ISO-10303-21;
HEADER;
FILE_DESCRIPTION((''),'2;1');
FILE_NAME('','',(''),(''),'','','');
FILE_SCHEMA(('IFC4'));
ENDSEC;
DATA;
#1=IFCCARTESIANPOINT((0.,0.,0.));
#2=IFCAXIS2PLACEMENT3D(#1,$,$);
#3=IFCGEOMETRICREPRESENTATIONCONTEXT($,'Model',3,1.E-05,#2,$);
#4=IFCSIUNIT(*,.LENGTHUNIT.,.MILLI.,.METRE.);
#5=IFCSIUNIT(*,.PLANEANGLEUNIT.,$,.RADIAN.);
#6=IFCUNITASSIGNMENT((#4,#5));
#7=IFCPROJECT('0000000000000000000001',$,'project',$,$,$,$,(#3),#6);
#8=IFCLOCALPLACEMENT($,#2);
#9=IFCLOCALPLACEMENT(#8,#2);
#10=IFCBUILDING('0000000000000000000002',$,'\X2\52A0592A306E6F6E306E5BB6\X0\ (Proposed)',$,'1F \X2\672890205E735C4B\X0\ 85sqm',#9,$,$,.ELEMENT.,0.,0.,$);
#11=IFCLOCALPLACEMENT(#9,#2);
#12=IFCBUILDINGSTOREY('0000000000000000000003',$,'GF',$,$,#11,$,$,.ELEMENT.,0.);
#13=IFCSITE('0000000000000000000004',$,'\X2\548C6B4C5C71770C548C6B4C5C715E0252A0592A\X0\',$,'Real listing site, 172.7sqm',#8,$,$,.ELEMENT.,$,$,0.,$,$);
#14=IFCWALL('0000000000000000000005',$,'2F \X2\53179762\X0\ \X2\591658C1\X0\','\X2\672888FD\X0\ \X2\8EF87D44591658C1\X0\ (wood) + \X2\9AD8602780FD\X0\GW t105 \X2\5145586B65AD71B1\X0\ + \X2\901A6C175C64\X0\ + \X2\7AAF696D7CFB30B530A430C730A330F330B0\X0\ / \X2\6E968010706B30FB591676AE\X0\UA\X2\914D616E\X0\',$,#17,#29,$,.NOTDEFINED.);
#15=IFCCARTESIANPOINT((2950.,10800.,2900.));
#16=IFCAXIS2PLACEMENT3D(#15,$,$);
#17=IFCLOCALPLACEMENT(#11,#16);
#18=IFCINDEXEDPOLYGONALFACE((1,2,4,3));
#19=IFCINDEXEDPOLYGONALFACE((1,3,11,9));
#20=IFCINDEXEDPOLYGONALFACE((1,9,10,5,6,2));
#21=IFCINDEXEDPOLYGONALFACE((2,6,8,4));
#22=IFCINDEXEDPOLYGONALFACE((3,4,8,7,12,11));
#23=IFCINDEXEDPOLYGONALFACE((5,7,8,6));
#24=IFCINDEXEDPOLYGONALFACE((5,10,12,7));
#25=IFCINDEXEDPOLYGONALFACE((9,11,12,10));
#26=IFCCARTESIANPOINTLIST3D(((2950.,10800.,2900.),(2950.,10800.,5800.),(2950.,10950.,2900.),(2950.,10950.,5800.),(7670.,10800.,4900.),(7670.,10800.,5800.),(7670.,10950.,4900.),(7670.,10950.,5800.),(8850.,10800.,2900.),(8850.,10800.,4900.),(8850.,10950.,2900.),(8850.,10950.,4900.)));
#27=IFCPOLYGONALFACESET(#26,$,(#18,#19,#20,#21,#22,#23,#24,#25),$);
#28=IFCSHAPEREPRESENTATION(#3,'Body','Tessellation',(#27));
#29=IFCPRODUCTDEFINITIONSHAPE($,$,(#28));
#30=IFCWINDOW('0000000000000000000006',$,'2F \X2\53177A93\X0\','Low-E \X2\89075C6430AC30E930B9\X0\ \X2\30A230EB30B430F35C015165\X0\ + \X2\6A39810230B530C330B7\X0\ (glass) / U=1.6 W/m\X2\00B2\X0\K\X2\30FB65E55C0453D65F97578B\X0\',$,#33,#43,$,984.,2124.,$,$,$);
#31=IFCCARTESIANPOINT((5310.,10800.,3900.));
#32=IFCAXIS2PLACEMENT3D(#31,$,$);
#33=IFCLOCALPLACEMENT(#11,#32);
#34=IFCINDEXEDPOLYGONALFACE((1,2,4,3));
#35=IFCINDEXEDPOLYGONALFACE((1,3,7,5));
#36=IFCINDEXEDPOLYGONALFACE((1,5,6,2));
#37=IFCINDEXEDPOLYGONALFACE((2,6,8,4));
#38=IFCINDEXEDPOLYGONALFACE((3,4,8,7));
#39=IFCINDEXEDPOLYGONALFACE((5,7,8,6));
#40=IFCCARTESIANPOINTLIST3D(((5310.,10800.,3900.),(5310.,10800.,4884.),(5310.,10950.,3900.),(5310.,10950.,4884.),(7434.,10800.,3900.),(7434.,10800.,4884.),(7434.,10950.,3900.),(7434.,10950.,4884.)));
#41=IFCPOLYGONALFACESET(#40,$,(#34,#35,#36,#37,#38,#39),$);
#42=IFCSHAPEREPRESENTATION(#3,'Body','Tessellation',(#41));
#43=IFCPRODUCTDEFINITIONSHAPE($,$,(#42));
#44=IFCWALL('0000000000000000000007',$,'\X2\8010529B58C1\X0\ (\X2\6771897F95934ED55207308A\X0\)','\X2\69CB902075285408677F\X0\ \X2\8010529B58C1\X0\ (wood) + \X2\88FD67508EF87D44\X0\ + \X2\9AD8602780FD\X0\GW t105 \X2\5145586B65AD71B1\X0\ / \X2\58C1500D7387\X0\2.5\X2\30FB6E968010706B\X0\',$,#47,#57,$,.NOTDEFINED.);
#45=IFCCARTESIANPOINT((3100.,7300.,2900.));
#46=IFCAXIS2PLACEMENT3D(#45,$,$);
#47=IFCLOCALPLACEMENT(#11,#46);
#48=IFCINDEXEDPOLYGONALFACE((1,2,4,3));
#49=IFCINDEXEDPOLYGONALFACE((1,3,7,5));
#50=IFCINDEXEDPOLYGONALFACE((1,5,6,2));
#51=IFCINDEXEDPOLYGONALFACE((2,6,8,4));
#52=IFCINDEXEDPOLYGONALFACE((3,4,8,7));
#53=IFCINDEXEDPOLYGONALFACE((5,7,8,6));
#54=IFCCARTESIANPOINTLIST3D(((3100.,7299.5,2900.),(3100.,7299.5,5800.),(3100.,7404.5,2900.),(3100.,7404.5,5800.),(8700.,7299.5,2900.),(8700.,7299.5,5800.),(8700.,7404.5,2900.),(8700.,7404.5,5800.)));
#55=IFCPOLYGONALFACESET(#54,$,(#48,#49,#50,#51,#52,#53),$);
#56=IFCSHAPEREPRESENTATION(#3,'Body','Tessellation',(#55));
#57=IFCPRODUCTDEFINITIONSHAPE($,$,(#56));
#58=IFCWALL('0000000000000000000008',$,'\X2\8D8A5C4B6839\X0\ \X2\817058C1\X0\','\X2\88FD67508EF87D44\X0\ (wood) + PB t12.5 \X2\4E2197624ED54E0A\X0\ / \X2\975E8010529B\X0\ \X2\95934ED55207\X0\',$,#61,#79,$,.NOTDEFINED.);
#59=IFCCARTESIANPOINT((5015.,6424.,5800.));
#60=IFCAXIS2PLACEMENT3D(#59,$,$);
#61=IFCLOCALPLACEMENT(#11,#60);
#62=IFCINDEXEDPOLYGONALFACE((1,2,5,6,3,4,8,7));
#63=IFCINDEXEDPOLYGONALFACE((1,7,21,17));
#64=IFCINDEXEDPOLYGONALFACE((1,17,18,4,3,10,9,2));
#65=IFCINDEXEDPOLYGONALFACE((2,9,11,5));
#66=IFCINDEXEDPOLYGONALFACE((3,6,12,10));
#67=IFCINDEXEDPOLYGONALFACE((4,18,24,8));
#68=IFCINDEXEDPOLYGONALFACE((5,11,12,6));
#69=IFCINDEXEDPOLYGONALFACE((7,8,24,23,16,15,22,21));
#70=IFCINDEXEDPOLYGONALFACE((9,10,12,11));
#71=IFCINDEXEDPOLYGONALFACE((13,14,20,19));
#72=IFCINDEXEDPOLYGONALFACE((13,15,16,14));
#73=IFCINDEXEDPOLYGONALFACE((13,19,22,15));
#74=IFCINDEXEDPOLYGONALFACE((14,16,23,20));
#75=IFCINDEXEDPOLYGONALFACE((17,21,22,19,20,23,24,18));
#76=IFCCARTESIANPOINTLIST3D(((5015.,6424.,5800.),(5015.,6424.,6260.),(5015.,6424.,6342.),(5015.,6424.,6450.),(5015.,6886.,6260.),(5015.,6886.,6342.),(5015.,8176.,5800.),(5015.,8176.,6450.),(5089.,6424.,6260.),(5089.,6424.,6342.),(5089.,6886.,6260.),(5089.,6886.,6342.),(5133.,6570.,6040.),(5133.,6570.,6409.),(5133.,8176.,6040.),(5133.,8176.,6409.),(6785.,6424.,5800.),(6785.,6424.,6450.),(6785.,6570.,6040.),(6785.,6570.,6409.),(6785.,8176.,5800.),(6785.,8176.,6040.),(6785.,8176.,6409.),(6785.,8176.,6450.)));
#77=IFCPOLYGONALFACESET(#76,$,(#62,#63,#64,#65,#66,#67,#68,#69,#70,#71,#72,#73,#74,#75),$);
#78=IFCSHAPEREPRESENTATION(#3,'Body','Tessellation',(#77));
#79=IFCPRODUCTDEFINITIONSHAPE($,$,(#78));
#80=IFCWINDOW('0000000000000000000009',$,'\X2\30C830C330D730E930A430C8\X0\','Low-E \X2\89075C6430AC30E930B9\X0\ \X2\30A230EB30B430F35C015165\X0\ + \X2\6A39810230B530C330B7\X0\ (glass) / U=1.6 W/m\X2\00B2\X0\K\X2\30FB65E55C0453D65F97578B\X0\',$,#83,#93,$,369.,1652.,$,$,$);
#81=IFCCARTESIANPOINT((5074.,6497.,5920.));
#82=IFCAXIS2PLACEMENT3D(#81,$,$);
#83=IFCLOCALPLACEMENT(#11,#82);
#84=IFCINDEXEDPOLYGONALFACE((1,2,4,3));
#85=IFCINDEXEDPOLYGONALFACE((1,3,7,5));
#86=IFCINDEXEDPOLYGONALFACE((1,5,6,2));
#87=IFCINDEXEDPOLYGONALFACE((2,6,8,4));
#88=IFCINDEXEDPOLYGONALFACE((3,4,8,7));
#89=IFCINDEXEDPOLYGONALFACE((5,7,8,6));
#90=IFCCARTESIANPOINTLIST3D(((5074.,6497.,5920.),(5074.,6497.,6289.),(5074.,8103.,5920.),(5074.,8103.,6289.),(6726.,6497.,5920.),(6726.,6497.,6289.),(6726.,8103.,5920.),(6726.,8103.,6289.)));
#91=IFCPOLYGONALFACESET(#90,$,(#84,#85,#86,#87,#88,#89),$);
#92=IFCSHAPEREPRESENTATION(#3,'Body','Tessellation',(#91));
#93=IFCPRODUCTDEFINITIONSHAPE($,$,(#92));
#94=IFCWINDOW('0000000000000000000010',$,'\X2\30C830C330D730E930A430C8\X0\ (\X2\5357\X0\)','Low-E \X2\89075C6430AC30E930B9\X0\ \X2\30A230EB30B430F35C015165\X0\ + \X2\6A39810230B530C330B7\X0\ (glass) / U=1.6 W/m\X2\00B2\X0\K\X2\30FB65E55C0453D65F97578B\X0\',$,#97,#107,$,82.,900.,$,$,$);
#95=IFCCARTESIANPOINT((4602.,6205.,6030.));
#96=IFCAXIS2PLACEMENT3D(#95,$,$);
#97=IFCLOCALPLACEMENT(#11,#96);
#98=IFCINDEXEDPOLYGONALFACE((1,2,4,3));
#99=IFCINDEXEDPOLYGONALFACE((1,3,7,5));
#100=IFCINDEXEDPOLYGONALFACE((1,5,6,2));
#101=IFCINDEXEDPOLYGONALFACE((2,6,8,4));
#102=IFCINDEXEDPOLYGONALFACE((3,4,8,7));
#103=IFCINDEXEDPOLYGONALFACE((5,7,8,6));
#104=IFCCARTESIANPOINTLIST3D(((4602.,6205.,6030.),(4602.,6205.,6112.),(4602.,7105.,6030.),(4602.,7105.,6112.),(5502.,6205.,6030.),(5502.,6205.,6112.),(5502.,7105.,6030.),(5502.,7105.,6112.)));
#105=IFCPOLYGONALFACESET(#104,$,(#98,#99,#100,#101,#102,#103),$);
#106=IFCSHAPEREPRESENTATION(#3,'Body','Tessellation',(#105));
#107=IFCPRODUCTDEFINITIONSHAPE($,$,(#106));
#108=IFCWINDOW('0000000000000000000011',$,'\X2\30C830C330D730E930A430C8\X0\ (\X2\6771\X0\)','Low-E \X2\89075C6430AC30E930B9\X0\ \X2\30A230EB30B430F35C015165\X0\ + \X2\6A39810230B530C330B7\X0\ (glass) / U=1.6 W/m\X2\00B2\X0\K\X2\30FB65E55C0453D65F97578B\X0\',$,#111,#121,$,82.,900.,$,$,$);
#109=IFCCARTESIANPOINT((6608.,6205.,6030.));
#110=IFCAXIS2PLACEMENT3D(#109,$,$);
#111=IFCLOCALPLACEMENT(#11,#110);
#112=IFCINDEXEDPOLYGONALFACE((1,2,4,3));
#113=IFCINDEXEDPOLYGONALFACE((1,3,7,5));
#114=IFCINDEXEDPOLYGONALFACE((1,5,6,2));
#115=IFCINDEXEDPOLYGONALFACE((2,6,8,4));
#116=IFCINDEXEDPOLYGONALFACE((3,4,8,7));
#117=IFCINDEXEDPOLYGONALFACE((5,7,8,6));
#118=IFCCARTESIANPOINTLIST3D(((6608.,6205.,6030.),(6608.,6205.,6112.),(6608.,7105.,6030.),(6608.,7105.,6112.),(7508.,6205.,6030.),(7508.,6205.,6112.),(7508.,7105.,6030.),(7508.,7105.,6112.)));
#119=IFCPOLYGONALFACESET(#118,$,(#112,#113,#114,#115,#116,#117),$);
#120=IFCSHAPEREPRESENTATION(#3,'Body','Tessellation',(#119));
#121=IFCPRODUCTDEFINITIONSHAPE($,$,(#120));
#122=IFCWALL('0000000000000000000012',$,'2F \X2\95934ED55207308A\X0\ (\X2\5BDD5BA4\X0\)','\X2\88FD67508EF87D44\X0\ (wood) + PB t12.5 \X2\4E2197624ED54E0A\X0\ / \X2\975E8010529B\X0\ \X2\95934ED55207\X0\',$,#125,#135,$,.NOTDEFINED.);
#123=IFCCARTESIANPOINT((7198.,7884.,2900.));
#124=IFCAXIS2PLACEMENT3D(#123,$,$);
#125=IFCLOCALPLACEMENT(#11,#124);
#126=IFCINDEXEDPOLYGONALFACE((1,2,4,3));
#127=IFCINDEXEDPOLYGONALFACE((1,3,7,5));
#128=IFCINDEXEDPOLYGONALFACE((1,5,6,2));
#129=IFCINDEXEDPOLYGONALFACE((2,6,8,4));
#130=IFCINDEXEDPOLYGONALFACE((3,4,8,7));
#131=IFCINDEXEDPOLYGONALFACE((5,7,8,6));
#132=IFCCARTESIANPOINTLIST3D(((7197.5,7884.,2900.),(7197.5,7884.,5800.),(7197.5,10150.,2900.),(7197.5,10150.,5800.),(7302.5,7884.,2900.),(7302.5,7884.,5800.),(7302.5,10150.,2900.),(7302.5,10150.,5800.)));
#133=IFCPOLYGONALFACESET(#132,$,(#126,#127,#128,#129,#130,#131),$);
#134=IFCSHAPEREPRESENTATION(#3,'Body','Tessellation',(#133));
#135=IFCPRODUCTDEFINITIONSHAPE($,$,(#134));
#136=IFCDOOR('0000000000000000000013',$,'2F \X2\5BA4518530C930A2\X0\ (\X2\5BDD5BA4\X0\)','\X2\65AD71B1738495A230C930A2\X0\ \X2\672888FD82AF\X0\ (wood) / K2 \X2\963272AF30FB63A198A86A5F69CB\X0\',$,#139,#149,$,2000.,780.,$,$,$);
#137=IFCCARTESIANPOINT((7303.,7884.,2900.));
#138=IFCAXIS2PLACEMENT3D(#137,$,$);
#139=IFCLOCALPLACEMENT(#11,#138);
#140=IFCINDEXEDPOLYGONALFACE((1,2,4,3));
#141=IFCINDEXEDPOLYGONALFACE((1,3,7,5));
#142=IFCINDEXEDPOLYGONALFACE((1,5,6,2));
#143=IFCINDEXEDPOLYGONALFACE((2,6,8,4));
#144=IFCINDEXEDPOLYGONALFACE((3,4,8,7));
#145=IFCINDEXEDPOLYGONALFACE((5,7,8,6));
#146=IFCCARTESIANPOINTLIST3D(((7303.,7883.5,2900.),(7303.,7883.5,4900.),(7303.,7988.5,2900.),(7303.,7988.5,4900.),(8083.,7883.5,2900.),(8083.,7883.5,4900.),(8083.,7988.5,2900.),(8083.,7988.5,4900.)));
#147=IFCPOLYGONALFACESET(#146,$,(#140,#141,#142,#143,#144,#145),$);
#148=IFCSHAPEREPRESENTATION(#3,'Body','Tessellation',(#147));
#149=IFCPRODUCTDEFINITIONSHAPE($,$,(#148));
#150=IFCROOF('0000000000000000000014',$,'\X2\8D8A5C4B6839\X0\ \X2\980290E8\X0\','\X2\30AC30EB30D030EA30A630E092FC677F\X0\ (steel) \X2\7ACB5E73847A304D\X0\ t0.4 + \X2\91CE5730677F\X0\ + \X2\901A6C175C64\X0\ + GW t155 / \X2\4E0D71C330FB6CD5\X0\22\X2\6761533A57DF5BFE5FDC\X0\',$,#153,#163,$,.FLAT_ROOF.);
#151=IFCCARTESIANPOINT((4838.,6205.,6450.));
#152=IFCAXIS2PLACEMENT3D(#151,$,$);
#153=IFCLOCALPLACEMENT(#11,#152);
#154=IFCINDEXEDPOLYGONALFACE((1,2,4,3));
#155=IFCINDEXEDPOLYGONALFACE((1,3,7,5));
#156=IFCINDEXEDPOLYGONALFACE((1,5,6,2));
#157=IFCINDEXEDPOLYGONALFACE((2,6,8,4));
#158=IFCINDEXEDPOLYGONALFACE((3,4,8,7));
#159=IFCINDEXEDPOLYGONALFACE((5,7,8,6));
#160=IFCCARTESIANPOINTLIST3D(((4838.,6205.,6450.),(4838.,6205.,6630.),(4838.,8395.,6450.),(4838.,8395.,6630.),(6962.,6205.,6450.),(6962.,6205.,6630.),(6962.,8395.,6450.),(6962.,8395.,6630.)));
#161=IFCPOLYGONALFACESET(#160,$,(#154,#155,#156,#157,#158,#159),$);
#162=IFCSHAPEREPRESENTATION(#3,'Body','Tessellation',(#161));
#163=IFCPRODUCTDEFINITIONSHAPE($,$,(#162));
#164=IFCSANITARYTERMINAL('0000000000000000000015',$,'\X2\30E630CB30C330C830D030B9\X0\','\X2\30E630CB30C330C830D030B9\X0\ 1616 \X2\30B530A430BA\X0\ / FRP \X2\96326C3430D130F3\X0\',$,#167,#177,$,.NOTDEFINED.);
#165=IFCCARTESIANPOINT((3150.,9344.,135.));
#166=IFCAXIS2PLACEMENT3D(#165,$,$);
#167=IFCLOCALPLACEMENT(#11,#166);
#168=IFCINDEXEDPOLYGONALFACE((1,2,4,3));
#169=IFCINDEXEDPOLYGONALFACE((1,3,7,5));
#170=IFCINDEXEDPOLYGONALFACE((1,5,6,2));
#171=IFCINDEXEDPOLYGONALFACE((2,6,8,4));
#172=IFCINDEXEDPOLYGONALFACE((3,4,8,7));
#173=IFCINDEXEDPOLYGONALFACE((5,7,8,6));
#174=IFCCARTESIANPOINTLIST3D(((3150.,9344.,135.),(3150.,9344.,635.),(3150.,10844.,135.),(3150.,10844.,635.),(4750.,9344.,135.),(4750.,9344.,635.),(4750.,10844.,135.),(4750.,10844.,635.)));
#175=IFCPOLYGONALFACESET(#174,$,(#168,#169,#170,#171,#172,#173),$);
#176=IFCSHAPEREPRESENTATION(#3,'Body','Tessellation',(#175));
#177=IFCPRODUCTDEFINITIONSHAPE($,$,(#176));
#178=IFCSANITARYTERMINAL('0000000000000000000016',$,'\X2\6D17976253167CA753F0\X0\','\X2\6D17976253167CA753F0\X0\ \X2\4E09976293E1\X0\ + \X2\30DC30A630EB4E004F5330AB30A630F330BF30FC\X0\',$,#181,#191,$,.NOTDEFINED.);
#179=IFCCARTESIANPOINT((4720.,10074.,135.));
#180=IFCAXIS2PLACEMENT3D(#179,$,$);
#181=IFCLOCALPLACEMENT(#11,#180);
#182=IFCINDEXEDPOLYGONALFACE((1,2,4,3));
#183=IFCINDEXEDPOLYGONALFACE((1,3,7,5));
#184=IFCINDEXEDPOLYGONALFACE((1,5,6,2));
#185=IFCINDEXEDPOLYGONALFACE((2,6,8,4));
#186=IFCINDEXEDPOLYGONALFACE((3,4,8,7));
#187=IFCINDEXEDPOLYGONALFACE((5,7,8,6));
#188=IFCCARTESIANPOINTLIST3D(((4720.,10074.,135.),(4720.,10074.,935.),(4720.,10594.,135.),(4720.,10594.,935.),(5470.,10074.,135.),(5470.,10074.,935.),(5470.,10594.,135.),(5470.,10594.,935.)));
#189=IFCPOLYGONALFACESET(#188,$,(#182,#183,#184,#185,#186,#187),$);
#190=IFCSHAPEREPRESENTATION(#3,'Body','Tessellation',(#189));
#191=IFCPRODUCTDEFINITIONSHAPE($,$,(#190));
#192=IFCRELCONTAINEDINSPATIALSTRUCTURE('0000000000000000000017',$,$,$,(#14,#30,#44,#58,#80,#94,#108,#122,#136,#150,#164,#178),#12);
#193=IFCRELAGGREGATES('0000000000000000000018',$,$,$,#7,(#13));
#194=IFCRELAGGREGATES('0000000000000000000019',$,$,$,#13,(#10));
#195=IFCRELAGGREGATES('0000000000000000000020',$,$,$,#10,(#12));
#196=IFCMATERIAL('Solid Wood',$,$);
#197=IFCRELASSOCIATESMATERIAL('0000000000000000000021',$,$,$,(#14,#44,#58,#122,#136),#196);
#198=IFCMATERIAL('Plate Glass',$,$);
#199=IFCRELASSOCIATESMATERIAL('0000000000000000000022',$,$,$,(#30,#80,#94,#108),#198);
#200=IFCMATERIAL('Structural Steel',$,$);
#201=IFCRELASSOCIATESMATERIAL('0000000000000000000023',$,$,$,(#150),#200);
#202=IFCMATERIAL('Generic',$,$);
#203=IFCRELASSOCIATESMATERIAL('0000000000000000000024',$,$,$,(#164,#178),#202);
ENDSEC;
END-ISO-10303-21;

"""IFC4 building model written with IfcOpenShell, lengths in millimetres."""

from ifc_helpers import new_model, si_unit, frame, frame_2d, origin, place, context, project, spatial, rectangle, extrude, material, element, fill, save


model = new_model("IFC4")

# Units and contexts
model_context = context("Model", 3, precision=1e-05, world=origin())
ifc_project = project(units=[si_unit("LENGTHUNIT", "METRE", prefix="MILLI"), si_unit("PLANEANGLEUNIT", "RADIAN")], contexts=[model_context])

# Site, building, storey
site_placement = place(None, origin())
site = spatial("IfcSite", under=ifc_project, at=site_placement, Name="和歌山県和歌山市加太", ObjectType="Real listing site, 172.7sqm", CompositionType="ELEMENT", RefElevation=0.0)
building_placement = place(site_placement, origin())
building = spatial("IfcBuilding", under=site, at=building_placement, Name="加太の潮の家 (Proposed)", ObjectType="1F 木造平屋 85sqm", CompositionType="ELEMENT", ElevationOfRefHeight=0.0, ElevationOfTerrain=0.0)
storey_placement = place(building_placement, origin())
storey = spatial("IfcBuildingStorey", under=building, at=storey_placement, Name="GF", CompositionType="ELEMENT", Elevation=0.0)

# Wall, opening, window
ifc_material_1 = material(Name="Solid Wood")
wall_1_placement = place(storey_placement, frame((2950.0, 10800.0, 2900.0)))
wall_1 = element("IfcWall", 1, at=wall_1_placement, inside=storey, material=ifc_material_1, Name="2F 北面 外壁", Description="木製 軸組外壁 (wood) + 高性能GW t105 充填断熱 + 通気層 + 窯業系サイディング / 準耐火・外皮UA配慮", PredefinedType="NOTDEFINED", context=model_context, shape_type="SweptSolid", body=[
    extrude(rectangle(XDim=5900.0, YDim=150.0, at=frame_2d((2950.0, 75.0))), frame((2950.0, 10800.0, 2900.0)), (0.0, 0.0, 1.0), 2900.0),
])
opening_1_placement = place(storey_placement, frame((5310.0, 10800.0, 3900.0)))
opening_1 = element("IfcOpeningElement", 2, at=opening_1_placement, cuts=wall_1, PredefinedType="NOTDEFINED", context=model_context, shape_type="SweptSolid", body=[
    extrude(rectangle(XDim=2124.0, YDim=150.0, at=frame_2d((1062.0, 75.0))), frame((5310.0, 10800.0, 3900.0)), (0.0, 0.0, 1.0), 984.0),
])
ifc_material_2 = material(Name="Plate Glass")
window_1_placement = place(storey_placement, frame((5310.0, 10800.0, 3900.0)))
window_1 = element("IfcWindow", 3, at=window_1_placement, inside=storey, material=ifc_material_2, Name="2F 北窓", Description="Low-E 複層ガラス アルゴン封入 + 樹脂サッシ (glass) / U=1.6 W/m²K・日射取得型", OverallHeight=984.0, OverallWidth=2124.0, context=model_context, shape_type="SweptSolid", body=[
    extrude(rectangle(XDim=2124.0, YDim=150.0, at=frame_2d((1062.0, 75.0))), frame((5310.0, 10800.0, 3900.0)), (0.0, 0.0, 1.0), 984.0),
])
fill(opening_1, window_1)

# Wall
wall_2_placement = place(storey_placement, frame((3100.0, 7300.0, 2900.0)))
element("IfcWall", 4, at=wall_2_placement, inside=storey, material=ifc_material_1, Name="耐力壁 (東西間仕切り)", Description="構造用合板 耐力壁 (wood) + 製材軸組 + 高性能GW t105 充填断熱 / 壁倍率2.5・準耐火", PredefinedType="NOTDEFINED", context=model_context, shape_type="SweptSolid", body=[
    extrude(rectangle(XDim=5600.0, YDim=105.0, at=frame_2d((2800.0, 52.0))), frame((3100.0, 7300.0, 2900.0)), (0.0, 0.0, 1.0), 2900.0),
])

# Wall, openings, windows
wall_3_placement = place(storey_placement, frame((5015.0, 6424.0, 5800.0)))
wall_3 = element("IfcWall", 5, at=wall_3_placement, inside=storey, material=ifc_material_1, Name="越屋根 腰壁", Description="製材軸組 (wood) + PB t12.5 両面仕上 / 非耐力 間仕切", PredefinedType="NOTDEFINED", context=model_context, shape_type="SweptSolid", body=[
    extrude(rectangle(XDim=1770.0, YDim=1752.0, at=frame_2d((885.0, 876.0))), frame((5015.0, 6424.0, 5800.0)), (0.0, 0.0, 1.0), 650.0),
])
opening_2_placement = place(storey_placement, frame((5074.0, 6497.0, 5920.0)))
opening_2 = element("IfcOpeningElement", 6, at=opening_2_placement, cuts=wall_3, PredefinedType="NOTDEFINED", context=model_context, shape_type="SweptSolid", body=[
    extrude(rectangle(XDim=1652.0, YDim=1606.0, at=frame_2d((826.0, 803.0))), frame((5074.0, 6497.0, 5920.0)), (0.0, 0.0, 1.0), 369.0),
])
opening_3_placement = place(storey_placement, frame((4602.0, 6205.0, 6030.0)))
opening_3 = element("IfcOpeningElement", 7, at=opening_3_placement, cuts=wall_3, PredefinedType="NOTDEFINED", context=model_context, shape_type="SweptSolid", body=[
    extrude(rectangle(XDim=900.0, YDim=900.0, at=frame_2d((450.0, 450.0))), frame((4602.0, 6205.0, 6030.0)), (0.0, 0.0, 1.0), 82.0),
])
opening_4_placement = place(storey_placement, frame((6608.0, 6205.0, 6030.0)))
opening_4 = element("IfcOpeningElement", 8, at=opening_4_placement, cuts=wall_3, PredefinedType="NOTDEFINED", context=model_context, shape_type="SweptSolid", body=[
    extrude(rectangle(XDim=900.0, YDim=900.0, at=frame_2d((450.0, 450.0))), frame((6608.0, 6205.0, 6030.0)), (0.0, 0.0, 1.0), 82.0),
])
window_2_placement = place(storey_placement, frame((5074.0, 6497.0, 5920.0)))
window_2 = element("IfcWindow", 9, at=window_2_placement, inside=storey, material=ifc_material_2, Name="トップライト", Description="Low-E 複層ガラス アルゴン封入 + 樹脂サッシ (glass) / U=1.6 W/m²K・日射取得型", OverallHeight=369.0, OverallWidth=1652.0, context=model_context, shape_type="SweptSolid", body=[
    extrude(rectangle(XDim=1652.0, YDim=1606.0, at=frame_2d((826.0, 803.0))), frame((5074.0, 6497.0, 5920.0)), (0.0, 0.0, 1.0), 369.0),
])
fill(opening_2, window_2)
window_3_placement = place(storey_placement, frame((4602.0, 6205.0, 6030.0)))
window_3 = element("IfcWindow", 10, at=window_3_placement, inside=storey, material=ifc_material_2, Name="トップライト (南)", Description="Low-E 複層ガラス アルゴン封入 + 樹脂サッシ (glass) / U=1.6 W/m²K・日射取得型", OverallHeight=82.0, OverallWidth=900.0, context=model_context, shape_type="SweptSolid", body=[
    extrude(rectangle(XDim=900.0, YDim=900.0, at=frame_2d((450.0, 450.0))), frame((4602.0, 6205.0, 6030.0)), (0.0, 0.0, 1.0), 82.0),
])
fill(opening_3, window_3)
window_4_placement = place(storey_placement, frame((6608.0, 6205.0, 6030.0)))
window_4 = element("IfcWindow", 11, at=window_4_placement, inside=storey, material=ifc_material_2, Name="トップライト (東)", Description="Low-E 複層ガラス アルゴン封入 + 樹脂サッシ (glass) / U=1.6 W/m²K・日射取得型", OverallHeight=82.0, OverallWidth=900.0, context=model_context, shape_type="SweptSolid", body=[
    extrude(rectangle(XDim=900.0, YDim=900.0, at=frame_2d((450.0, 450.0))), frame((6608.0, 6205.0, 6030.0)), (0.0, 0.0, 1.0), 82.0),
])
fill(opening_4, window_4)

# Wall
wall_4_placement = place(storey_placement, frame((7198.0, 7884.0, 2900.0)))
element("IfcWall", 12, at=wall_4_placement, inside=storey, material=ifc_material_1, Name="2F 間仕切り (寝室)", Description="製材軸組 (wood) + PB t12.5 両面仕上 / 非耐力 間仕切", PredefinedType="NOTDEFINED", context=model_context, shape_type="SweptSolid", body=[
    extrude(rectangle(XDim=105.0, YDim=2266.0, at=frame_2d((52.0, 1133.0))), frame((7198.0, 7884.0, 2900.0)), (0.0, 0.0, 1.0), 2900.0),
])

# Door
door_placement = place(storey_placement, frame((7303.0, 7884.0, 2900.0)))
element("IfcDoor", 13, at=door_placement, inside=storey, material=ifc_material_1, Name="2F 室内ドア (寝室)", Description="断熱玄関ドア 木製芯 (wood) / K2 防犯・採風機構", OverallHeight=2000.0, OverallWidth=780.0, context=model_context, shape_type="SweptSolid", body=[
    extrude(rectangle(XDim=780.0, YDim=105.0, at=frame_2d((390.0, 52.0))), frame((7303.0, 7884.0, 2900.0)), (0.0, 0.0, 1.0), 2000.0),
])

# Roof
ifc_material_3 = material(Name="Structural Steel")
roof_placement = place(storey_placement, frame((4838.0, 6205.0, 6450.0)))
element("IfcRoof", 14, at=roof_placement, inside=storey, material=ifc_material_3, Name="越屋根 頂部", Description="ガルバリウム鋼板 (steel) 立平葺き t0.4 + 野地板 + 通気層 + GW t155 / 不燃・法22条区域対応", PredefinedType="FLAT_ROOF", context=model_context, shape_type="SweptSolid", body=[
    extrude(rectangle(XDim=2124.0, YDim=2190.0, at=frame_2d((1062.0, 1095.0))), frame((4838.0, 6205.0, 6450.0)), (0.0, 0.0, 1.0), 180.0),
])

# Sanitary terminals
ifc_material_4 = material(Name="Generic")
sanitary_terminal_1_placement = place(storey_placement, frame((3150.0, 9344.0, 135.0)))
element("IfcSanitaryTerminal", 15, at=sanitary_terminal_1_placement, inside=storey, material=ifc_material_4, Name="ユニットバス", Description="ユニットバス 1616 サイズ / FRP 防水パン", PredefinedType="NOTDEFINED", context=model_context, shape_type="SweptSolid", body=[
    extrude(rectangle(XDim=1600.0, YDim=1500.0, at=frame_2d((800.0, 750.0))), frame((3150.0, 9344.0, 135.0)), (0.0, 0.0, 1.0), 500.0),
])
sanitary_terminal_2_placement = place(storey_placement, frame((4720.0, 10074.0, 135.0)))
element("IfcSanitaryTerminal", 16, at=sanitary_terminal_2_placement, inside=storey, material=ifc_material_4, Name="洗面化粧台", Description="洗面化粧台 三面鏡 + ボウル一体カウンター", PredefinedType="NOTDEFINED", context=model_context, shape_type="SweptSolid", body=[
    extrude(rectangle(XDim=750.0, YDim=520.0, at=frame_2d((375.0, 260.0))), frame((4720.0, 10074.0, 135.0)), (0.0, 0.0, 1.0), 800.0),
])

save(model, "model.ifc")
